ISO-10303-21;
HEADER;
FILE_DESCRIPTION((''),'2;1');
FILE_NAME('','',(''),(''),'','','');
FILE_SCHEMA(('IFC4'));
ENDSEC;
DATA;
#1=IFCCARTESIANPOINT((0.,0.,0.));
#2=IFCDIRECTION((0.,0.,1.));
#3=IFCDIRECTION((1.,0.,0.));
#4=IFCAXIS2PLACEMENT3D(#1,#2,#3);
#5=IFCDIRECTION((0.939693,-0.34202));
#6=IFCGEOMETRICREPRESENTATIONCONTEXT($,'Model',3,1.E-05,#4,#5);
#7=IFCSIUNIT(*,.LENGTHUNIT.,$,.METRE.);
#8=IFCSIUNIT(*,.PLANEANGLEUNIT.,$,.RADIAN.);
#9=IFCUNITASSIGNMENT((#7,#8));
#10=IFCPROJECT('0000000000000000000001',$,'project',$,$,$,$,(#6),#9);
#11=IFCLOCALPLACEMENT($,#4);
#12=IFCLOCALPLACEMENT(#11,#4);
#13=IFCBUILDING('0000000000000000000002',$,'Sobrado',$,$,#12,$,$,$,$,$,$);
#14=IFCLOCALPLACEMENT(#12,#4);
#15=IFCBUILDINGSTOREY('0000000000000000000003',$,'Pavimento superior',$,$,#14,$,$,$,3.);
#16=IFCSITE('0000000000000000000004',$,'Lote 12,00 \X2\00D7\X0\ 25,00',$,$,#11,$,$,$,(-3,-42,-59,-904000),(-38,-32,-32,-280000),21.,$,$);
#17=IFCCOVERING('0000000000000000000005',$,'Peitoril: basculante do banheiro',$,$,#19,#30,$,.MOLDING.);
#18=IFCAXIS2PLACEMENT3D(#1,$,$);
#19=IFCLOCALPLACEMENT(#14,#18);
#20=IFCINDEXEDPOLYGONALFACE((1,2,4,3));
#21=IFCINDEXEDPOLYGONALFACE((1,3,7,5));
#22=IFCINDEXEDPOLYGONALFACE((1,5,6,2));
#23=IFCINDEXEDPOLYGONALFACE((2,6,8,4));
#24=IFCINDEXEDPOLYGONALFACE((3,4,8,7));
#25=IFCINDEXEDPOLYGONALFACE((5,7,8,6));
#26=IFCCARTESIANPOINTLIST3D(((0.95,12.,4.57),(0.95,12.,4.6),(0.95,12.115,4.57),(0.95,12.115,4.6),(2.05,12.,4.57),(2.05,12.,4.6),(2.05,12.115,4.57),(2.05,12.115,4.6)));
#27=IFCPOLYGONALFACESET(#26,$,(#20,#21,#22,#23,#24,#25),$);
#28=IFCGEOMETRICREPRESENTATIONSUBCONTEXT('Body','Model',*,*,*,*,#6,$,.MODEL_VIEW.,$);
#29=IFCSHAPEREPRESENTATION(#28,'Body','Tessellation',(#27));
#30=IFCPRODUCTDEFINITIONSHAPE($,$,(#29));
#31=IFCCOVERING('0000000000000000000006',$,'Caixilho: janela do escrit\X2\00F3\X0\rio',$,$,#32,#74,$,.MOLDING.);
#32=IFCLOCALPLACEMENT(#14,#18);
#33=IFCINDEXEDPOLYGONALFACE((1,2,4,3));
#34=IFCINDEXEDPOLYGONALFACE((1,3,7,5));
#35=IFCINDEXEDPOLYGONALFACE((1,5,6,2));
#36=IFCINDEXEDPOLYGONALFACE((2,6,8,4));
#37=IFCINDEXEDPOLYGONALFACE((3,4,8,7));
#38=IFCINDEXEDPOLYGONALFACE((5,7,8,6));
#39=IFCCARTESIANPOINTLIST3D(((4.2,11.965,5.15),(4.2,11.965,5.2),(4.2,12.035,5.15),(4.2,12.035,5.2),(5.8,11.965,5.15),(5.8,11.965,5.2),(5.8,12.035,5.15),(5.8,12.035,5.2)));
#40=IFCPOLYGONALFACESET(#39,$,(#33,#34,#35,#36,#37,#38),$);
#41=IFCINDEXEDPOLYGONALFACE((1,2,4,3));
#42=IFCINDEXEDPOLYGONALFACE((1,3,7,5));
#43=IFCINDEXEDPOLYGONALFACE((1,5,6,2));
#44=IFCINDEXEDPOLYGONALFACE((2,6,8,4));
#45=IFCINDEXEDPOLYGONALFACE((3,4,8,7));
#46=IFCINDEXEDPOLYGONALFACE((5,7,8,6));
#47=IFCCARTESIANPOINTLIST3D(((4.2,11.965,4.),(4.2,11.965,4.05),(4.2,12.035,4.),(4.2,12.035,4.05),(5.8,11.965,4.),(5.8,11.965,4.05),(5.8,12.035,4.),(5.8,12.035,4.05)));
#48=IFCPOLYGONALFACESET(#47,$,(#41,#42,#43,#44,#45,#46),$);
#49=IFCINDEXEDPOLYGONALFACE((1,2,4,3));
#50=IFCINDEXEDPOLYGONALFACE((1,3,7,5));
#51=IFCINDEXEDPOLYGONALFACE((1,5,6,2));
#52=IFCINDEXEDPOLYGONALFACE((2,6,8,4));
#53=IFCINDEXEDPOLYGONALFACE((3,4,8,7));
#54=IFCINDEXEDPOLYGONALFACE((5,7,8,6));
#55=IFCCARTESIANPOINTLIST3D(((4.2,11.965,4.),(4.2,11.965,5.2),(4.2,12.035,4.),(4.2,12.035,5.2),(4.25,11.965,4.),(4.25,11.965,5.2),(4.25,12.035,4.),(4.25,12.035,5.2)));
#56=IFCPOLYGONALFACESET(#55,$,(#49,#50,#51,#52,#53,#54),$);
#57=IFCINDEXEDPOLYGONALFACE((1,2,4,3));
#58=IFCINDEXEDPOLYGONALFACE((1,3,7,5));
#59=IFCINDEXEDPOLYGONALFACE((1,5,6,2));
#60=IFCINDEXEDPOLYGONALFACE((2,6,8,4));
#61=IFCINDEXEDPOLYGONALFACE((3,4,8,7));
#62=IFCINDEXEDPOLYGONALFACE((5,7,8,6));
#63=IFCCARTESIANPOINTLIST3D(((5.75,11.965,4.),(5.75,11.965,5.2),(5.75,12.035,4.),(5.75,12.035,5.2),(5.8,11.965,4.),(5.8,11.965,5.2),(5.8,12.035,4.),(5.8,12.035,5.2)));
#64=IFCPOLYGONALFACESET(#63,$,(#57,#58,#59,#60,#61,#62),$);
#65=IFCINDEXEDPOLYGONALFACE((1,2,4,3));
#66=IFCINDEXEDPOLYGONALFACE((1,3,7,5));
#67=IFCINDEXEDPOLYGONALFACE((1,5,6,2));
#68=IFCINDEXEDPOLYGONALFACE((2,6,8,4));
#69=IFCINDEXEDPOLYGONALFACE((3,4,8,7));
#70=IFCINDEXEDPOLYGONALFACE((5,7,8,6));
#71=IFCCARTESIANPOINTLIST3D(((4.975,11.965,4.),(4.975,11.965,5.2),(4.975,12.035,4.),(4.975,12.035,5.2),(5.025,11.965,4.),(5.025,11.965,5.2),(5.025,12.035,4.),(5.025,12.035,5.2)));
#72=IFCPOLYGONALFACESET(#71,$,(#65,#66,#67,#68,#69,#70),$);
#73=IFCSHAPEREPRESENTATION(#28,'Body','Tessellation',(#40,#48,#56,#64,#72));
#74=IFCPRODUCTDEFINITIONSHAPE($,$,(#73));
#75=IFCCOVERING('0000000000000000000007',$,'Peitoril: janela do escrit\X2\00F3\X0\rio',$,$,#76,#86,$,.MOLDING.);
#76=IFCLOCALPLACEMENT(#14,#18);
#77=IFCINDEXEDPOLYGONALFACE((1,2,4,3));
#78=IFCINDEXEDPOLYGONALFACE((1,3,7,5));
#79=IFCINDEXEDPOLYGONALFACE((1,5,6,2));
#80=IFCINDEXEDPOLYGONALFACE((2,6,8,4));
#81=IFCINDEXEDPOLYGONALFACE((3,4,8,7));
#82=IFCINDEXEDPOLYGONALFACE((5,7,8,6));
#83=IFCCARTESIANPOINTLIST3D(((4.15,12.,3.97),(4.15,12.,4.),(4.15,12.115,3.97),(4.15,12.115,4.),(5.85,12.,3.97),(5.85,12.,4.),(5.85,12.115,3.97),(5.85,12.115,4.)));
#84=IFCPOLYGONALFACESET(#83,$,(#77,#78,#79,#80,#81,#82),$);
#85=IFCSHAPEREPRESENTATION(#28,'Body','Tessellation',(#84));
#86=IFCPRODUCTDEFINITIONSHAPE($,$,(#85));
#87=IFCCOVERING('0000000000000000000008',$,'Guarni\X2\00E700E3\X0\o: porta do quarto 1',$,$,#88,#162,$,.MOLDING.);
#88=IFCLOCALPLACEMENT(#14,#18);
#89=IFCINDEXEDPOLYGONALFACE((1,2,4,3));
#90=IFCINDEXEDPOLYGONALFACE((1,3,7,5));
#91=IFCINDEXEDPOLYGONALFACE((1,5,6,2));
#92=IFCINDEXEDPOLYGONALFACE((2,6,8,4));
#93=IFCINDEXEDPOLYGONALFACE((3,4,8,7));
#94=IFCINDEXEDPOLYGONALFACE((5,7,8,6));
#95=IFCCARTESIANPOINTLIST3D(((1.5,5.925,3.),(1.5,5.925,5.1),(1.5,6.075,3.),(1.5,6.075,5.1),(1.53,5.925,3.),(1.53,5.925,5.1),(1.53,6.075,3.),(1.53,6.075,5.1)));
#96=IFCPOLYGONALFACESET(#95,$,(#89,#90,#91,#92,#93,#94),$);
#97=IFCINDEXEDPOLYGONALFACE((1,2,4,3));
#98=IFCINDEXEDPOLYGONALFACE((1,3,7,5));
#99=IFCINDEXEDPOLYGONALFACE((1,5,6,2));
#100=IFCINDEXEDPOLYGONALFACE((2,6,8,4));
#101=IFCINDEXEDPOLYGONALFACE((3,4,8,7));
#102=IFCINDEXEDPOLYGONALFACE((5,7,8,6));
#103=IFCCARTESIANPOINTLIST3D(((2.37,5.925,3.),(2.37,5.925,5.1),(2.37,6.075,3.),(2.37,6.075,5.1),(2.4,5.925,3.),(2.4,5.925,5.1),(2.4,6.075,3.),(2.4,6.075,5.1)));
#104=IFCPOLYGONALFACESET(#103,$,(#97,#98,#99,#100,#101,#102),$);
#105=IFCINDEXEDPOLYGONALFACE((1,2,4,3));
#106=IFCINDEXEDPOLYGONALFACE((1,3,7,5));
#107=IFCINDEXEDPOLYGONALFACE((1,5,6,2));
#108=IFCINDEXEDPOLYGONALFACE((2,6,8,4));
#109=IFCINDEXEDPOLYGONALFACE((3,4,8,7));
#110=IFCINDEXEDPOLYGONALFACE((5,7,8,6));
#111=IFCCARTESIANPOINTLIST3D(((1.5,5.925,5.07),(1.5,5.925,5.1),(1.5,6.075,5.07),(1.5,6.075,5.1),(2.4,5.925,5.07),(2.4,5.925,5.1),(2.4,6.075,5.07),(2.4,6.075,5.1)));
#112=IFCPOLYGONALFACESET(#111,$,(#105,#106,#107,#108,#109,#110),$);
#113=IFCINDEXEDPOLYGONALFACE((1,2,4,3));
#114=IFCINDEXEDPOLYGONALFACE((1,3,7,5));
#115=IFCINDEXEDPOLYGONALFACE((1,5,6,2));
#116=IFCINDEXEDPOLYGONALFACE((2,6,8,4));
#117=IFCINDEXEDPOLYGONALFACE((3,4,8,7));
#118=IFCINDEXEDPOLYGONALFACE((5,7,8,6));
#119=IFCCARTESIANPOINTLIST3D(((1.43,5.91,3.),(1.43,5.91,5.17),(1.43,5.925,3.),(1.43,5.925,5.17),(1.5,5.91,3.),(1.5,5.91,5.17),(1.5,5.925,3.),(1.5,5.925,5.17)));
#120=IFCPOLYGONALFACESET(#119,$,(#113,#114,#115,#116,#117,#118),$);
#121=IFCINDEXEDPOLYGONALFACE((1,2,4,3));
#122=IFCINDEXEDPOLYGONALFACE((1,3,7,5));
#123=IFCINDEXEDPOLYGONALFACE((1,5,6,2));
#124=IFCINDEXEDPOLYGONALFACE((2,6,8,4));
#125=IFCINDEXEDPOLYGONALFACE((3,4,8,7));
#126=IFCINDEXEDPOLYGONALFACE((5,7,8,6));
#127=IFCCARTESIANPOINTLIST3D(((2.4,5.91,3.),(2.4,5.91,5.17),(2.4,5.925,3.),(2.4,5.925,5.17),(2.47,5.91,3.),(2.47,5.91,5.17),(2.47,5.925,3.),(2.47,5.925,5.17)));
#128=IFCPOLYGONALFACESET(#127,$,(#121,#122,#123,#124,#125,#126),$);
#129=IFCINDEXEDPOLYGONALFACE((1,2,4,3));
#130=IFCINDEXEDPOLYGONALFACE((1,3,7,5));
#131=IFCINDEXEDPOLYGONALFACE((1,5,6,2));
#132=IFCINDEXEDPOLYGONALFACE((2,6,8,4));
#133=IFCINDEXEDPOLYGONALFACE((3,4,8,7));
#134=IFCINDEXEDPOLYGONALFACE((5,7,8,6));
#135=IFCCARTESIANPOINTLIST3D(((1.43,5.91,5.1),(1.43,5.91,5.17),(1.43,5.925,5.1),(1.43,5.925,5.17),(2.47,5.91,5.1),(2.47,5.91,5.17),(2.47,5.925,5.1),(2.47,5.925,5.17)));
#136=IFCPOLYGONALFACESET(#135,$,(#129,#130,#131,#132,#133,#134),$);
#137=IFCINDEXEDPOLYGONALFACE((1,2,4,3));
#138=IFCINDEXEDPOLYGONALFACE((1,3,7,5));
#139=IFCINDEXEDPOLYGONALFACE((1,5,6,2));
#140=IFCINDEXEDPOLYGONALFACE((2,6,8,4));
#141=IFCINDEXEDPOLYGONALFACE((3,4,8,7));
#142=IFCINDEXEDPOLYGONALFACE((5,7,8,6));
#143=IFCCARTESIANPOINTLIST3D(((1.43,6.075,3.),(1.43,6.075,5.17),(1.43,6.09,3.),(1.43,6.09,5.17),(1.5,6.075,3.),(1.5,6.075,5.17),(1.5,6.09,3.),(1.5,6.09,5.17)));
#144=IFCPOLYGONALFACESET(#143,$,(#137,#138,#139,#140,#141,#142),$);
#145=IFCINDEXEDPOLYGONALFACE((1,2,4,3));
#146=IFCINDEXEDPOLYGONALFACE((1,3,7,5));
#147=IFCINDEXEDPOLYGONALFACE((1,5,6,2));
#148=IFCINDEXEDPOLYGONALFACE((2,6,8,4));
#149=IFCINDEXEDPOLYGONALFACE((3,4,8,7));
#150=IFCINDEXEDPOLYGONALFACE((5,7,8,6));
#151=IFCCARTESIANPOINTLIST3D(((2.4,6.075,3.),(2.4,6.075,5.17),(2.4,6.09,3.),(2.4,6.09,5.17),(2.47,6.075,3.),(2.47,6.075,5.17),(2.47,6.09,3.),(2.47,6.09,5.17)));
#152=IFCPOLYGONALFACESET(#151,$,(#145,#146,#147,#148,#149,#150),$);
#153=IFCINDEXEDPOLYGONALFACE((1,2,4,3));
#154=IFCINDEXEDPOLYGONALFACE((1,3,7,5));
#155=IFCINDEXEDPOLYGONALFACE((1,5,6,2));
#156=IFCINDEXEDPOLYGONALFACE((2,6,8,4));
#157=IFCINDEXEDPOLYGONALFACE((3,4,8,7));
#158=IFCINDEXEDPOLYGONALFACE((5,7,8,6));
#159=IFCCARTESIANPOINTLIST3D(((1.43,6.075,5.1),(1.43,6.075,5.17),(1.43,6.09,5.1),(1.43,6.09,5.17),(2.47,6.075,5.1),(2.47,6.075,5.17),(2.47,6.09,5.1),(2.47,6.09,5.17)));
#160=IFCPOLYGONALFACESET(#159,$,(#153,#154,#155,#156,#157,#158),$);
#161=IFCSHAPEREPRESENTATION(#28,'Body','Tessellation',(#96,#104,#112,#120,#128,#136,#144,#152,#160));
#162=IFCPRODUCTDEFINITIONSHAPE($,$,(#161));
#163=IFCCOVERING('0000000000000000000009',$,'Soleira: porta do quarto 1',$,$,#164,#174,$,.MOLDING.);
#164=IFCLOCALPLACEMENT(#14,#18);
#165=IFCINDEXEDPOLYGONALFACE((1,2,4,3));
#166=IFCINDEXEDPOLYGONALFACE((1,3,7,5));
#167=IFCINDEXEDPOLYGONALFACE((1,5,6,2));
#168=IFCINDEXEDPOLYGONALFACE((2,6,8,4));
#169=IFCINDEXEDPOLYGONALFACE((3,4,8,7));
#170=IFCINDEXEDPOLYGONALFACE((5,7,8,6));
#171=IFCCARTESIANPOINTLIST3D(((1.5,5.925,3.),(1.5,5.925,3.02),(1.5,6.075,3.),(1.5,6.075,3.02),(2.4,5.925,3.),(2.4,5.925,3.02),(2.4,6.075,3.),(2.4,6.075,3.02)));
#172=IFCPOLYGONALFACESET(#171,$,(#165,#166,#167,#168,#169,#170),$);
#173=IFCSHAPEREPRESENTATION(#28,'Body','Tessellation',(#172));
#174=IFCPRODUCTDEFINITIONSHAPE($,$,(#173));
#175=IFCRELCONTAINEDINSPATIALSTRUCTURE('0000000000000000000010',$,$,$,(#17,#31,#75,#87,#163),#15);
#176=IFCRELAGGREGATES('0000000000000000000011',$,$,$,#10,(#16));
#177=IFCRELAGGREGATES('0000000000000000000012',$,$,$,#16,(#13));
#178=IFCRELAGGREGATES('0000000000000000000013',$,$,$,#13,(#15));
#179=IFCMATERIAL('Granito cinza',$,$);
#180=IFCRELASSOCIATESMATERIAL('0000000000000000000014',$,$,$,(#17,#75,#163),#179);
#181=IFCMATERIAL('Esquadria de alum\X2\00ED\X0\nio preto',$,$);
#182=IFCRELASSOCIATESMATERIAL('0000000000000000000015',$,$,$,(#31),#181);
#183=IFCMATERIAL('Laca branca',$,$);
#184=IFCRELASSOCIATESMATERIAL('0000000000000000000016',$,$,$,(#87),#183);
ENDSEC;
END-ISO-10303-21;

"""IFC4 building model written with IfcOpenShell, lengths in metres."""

from ifc_helpers import new_model, si_unit, direction, frame, origin_with_axes, place, context, subcontext, project, spatial, line, indexed_curve, outline, extrude, material, element, save


model = new_model("IFC4")

# Units and contexts
model_context = context("Model", 3, precision=1e-05, world=origin_with_axes(), true_north=direction((0.939693, -0.34202)))
body_context = subcontext(model_context, "Body", "Model", "MODEL_VIEW")
ifc_project = project(units=[si_unit("LENGTHUNIT", "METRE"), si_unit("PLANEANGLEUNIT", "RADIAN")], contexts=[model_context])

# Site, building, storey
site_placement = place(None, origin_with_axes())
site = spatial("IfcSite", under=ifc_project, at=site_placement, Name="Lote 12,00 × 25,00", RefLatitude=(-3, -42, -59, -904000), RefLongitude=(-38, -32, -32, -280000), RefElevation=21.0)
building_placement = place(site_placement, origin_with_axes())
building = spatial("IfcBuilding", under=site, at=building_placement, Name="Sobrado")
storey_placement = place(building_placement, origin_with_axes())
storey = spatial("IfcBuildingStorey", under=building, at=storey_placement, Name="Pavimento superior", Elevation=3.0)

# Coverings
ifc_material_1 = material(Name="Esquadria de alumínio preto")
ifc_material_2 = material(Name="Granito cinza")
covering_1_placement = place(storey_placement, origin_with_axes())
element("IfcCovering", 1, at=covering_1_placement, inside=storey, material=ifc_material_2, Name="Peitoril: basculante do banheiro", PredefinedType="MOLDING", context=body_context, shape_type="SweptSolid", body=[
    extrude(outline(indexed_curve([(0.95, 12.0), (2.05, 12.0), (2.05, 12.115), (0.95, 12.115)], segments=[line(1, 2, 3, 4, 1)])), frame((0.0, 0.0, 4.57), z_axis=(0.0, 0.0, 1.0), x_axis=(1.0, 0.0, 0.0)), (0.0, 0.0, 1.0), 0.03),
])
covering_2_placement = place(storey_placement, origin_with_axes())
element("IfcCovering", 2, at=covering_2_placement, inside=storey, material=ifc_material_1, Name="Caixilho: janela do escritório", PredefinedType="MOLDING", context=body_context, shape_type="SweptSolid", body=[
    extrude(outline(indexed_curve([(4.2, 11.965), (5.8, 11.965), (5.8, 12.035), (4.2, 12.035)], segments=[line(1, 2, 3, 4, 1)])), frame((0.0, 0.0, 5.15), z_axis=(0.0, 0.0, 1.0), x_axis=(1.0, 0.0, 0.0)), (0.0, 0.0, 1.0), 0.05),
    extrude(outline(indexed_curve([(4.2, 11.965), (5.8, 11.965), (5.8, 12.035), (4.2, 12.035)], segments=[line(1, 2, 3, 4, 1)])), frame((0.0, 0.0, 4.0), z_axis=(0.0, 0.0, 1.0), x_axis=(1.0, 0.0, 0.0)), (0.0, 0.0, 1.0), 0.05),
    extrude(outline(indexed_curve([(4.2, 11.965), (4.25, 11.965), (4.25, 12.035), (4.2, 12.035)], segments=[line(1, 2, 3, 4, 1)])), frame((0.0, 0.0, 4.0), z_axis=(0.0, 0.0, 1.0), x_axis=(1.0, 0.0, 0.0)), (0.0, 0.0, 1.0), 1.2),
    extrude(outline(indexed_curve([(5.75, 11.965), (5.8, 11.965), (5.8, 12.035), (5.75, 12.035)], segments=[line(1, 2, 3, 4, 1)])), frame((0.0, 0.0, 4.0), z_axis=(0.0, 0.0, 1.0), x_axis=(1.0, 0.0, 0.0)), (0.0, 0.0, 1.0), 1.2),
    extrude(outline(indexed_curve([(4.975, 11.965), (5.025, 11.965), (5.025, 12.035), (4.975, 12.035)], segments=[line(1, 2, 3, 4, 1)])), frame((0.0, 0.0, 4.0), z_axis=(0.0, 0.0, 1.0), x_axis=(1.0, 0.0, 0.0)), (0.0, 0.0, 1.0), 1.2),
])
covering_3_placement = place(storey_placement, origin_with_axes())
element("IfcCovering", 3, at=covering_3_placement, inside=storey, material=ifc_material_2, Name="Peitoril: janela do escritório", PredefinedType="MOLDING", context=body_context, shape_type="SweptSolid", body=[
    extrude(outline(indexed_curve([(4.15, 12.0), (5.85, 12.0), (5.85, 12.115), (4.15, 12.115)], segments=[line(1, 2, 3, 4, 1)])), frame((0.0, 0.0, 3.97), z_axis=(0.0, 0.0, 1.0), x_axis=(1.0, 0.0, 0.0)), (0.0, 0.0, 1.0), 0.03),
])
ifc_material_3 = material(Name="Laca branca")
covering_4_placement = place(storey_placement, origin_with_axes())
element("IfcCovering", 4, at=covering_4_placement, inside=storey, material=ifc_material_3, Name="Guarnição: porta do quarto 1", PredefinedType="MOLDING", context=body_context, shape_type="SweptSolid", body=[
    extrude(outline(indexed_curve([(1.5, 5.925), (1.53, 5.925), (1.53, 6.075), (1.5, 6.075)], segments=[line(1, 2, 3, 4, 1)])), frame((0.0, 0.0, 3.0), z_axis=(0.0, 0.0, 1.0), x_axis=(1.0, 0.0, 0.0)), (0.0, 0.0, 1.0), 2.1),
    extrude(outline(indexed_curve([(2.37, 5.925), (2.4, 5.925), (2.4, 6.075), (2.37, 6.075)], segments=[line(1, 2, 3, 4, 1)])), frame((0.0, 0.0, 3.0), z_axis=(0.0, 0.0, 1.0), x_axis=(1.0, 0.0, 0.0)), (0.0, 0.0, 1.0), 2.1),
    extrude(outline(indexed_curve([(1.5, 5.925), (2.4, 5.925), (2.4, 6.075), (1.5, 6.075)], segments=[line(1, 2, 3, 4, 1)])), frame((0.0, 0.0, 5.07), z_axis=(0.0, 0.0, 1.0), x_axis=(1.0, 0.0, 0.0)), (0.0, 0.0, 1.0), 0.03),
    extrude(outline(indexed_curve([(1.43, 5.91), (1.5, 5.91), (1.5, 5.925), (1.43, 5.925)], segments=[line(1, 2, 3, 4, 1)])), frame((0.0, 0.0, 3.0), z_axis=(0.0, 0.0, 1.0), x_axis=(1.0, 0.0, 0.0)), (0.0, 0.0, 1.0), 2.17),
    extrude(outline(indexed_curve([(2.4, 5.91), (2.47, 5.91), (2.47, 5.925), (2.4, 5.925)], segments=[line(1, 2, 3, 4, 1)])), frame((0.0, 0.0, 3.0), z_axis=(0.0, 0.0, 1.0), x_axis=(1.0, 0.0, 0.0)), (0.0, 0.0, 1.0), 2.17),
    extrude(outline(indexed_curve([(1.43, 5.91), (2.47, 5.91), (2.47, 5.925), (1.43, 5.925)], segments=[line(1, 2, 3, 4, 1)])), frame((0.0, 0.0, 5.1), z_axis=(0.0, 0.0, 1.0), x_axis=(1.0, 0.0, 0.0)), (0.0, 0.0, 1.0), 0.07),
    extrude(outline(indexed_curve([(1.43, 6.075), (1.5, 6.075), (1.5, 6.09), (1.43, 6.09)], segments=[line(1, 2, 3, 4, 1)])), frame((0.0, 0.0, 3.0), z_axis=(0.0, 0.0, 1.0), x_axis=(1.0, 0.0, 0.0)), (0.0, 0.0, 1.0), 2.17),
    extrude(outline(indexed_curve([(2.4, 6.075), (2.47, 6.075), (2.47, 6.09), (2.4, 6.09)], segments=[line(1, 2, 3, 4, 1)])), frame((0.0, 0.0, 3.0), z_axis=(0.0, 0.0, 1.0), x_axis=(1.0, 0.0, 0.0)), (0.0, 0.0, 1.0), 2.17),
    extrude(outline(indexed_curve([(1.43, 6.075), (2.47, 6.075), (2.47, 6.09), (1.43, 6.09)], segments=[line(1, 2, 3, 4, 1)])), frame((0.0, 0.0, 5.1), z_axis=(0.0, 0.0, 1.0), x_axis=(1.0, 0.0, 0.0)), (0.0, 0.0, 1.0), 0.07),
])
covering_5_placement = place(storey_placement, origin_with_axes())
element("IfcCovering", 5, at=covering_5_placement, inside=storey, material=ifc_material_2, Name="Soleira: porta do quarto 1", PredefinedType="MOLDING", context=body_context, shape_type="SweptSolid", body=[
    extrude(outline(indexed_curve([(1.5, 5.925), (2.4, 5.925), (2.4, 6.075), (1.5, 6.075)], segments=[line(1, 2, 3, 4, 1)])), frame((0.0, 0.0, 3.0), z_axis=(0.0, 0.0, 1.0), x_axis=(1.0, 0.0, 0.0)), (0.0, 0.0, 1.0), 0.02),
])

save(model, "model.ifc")
